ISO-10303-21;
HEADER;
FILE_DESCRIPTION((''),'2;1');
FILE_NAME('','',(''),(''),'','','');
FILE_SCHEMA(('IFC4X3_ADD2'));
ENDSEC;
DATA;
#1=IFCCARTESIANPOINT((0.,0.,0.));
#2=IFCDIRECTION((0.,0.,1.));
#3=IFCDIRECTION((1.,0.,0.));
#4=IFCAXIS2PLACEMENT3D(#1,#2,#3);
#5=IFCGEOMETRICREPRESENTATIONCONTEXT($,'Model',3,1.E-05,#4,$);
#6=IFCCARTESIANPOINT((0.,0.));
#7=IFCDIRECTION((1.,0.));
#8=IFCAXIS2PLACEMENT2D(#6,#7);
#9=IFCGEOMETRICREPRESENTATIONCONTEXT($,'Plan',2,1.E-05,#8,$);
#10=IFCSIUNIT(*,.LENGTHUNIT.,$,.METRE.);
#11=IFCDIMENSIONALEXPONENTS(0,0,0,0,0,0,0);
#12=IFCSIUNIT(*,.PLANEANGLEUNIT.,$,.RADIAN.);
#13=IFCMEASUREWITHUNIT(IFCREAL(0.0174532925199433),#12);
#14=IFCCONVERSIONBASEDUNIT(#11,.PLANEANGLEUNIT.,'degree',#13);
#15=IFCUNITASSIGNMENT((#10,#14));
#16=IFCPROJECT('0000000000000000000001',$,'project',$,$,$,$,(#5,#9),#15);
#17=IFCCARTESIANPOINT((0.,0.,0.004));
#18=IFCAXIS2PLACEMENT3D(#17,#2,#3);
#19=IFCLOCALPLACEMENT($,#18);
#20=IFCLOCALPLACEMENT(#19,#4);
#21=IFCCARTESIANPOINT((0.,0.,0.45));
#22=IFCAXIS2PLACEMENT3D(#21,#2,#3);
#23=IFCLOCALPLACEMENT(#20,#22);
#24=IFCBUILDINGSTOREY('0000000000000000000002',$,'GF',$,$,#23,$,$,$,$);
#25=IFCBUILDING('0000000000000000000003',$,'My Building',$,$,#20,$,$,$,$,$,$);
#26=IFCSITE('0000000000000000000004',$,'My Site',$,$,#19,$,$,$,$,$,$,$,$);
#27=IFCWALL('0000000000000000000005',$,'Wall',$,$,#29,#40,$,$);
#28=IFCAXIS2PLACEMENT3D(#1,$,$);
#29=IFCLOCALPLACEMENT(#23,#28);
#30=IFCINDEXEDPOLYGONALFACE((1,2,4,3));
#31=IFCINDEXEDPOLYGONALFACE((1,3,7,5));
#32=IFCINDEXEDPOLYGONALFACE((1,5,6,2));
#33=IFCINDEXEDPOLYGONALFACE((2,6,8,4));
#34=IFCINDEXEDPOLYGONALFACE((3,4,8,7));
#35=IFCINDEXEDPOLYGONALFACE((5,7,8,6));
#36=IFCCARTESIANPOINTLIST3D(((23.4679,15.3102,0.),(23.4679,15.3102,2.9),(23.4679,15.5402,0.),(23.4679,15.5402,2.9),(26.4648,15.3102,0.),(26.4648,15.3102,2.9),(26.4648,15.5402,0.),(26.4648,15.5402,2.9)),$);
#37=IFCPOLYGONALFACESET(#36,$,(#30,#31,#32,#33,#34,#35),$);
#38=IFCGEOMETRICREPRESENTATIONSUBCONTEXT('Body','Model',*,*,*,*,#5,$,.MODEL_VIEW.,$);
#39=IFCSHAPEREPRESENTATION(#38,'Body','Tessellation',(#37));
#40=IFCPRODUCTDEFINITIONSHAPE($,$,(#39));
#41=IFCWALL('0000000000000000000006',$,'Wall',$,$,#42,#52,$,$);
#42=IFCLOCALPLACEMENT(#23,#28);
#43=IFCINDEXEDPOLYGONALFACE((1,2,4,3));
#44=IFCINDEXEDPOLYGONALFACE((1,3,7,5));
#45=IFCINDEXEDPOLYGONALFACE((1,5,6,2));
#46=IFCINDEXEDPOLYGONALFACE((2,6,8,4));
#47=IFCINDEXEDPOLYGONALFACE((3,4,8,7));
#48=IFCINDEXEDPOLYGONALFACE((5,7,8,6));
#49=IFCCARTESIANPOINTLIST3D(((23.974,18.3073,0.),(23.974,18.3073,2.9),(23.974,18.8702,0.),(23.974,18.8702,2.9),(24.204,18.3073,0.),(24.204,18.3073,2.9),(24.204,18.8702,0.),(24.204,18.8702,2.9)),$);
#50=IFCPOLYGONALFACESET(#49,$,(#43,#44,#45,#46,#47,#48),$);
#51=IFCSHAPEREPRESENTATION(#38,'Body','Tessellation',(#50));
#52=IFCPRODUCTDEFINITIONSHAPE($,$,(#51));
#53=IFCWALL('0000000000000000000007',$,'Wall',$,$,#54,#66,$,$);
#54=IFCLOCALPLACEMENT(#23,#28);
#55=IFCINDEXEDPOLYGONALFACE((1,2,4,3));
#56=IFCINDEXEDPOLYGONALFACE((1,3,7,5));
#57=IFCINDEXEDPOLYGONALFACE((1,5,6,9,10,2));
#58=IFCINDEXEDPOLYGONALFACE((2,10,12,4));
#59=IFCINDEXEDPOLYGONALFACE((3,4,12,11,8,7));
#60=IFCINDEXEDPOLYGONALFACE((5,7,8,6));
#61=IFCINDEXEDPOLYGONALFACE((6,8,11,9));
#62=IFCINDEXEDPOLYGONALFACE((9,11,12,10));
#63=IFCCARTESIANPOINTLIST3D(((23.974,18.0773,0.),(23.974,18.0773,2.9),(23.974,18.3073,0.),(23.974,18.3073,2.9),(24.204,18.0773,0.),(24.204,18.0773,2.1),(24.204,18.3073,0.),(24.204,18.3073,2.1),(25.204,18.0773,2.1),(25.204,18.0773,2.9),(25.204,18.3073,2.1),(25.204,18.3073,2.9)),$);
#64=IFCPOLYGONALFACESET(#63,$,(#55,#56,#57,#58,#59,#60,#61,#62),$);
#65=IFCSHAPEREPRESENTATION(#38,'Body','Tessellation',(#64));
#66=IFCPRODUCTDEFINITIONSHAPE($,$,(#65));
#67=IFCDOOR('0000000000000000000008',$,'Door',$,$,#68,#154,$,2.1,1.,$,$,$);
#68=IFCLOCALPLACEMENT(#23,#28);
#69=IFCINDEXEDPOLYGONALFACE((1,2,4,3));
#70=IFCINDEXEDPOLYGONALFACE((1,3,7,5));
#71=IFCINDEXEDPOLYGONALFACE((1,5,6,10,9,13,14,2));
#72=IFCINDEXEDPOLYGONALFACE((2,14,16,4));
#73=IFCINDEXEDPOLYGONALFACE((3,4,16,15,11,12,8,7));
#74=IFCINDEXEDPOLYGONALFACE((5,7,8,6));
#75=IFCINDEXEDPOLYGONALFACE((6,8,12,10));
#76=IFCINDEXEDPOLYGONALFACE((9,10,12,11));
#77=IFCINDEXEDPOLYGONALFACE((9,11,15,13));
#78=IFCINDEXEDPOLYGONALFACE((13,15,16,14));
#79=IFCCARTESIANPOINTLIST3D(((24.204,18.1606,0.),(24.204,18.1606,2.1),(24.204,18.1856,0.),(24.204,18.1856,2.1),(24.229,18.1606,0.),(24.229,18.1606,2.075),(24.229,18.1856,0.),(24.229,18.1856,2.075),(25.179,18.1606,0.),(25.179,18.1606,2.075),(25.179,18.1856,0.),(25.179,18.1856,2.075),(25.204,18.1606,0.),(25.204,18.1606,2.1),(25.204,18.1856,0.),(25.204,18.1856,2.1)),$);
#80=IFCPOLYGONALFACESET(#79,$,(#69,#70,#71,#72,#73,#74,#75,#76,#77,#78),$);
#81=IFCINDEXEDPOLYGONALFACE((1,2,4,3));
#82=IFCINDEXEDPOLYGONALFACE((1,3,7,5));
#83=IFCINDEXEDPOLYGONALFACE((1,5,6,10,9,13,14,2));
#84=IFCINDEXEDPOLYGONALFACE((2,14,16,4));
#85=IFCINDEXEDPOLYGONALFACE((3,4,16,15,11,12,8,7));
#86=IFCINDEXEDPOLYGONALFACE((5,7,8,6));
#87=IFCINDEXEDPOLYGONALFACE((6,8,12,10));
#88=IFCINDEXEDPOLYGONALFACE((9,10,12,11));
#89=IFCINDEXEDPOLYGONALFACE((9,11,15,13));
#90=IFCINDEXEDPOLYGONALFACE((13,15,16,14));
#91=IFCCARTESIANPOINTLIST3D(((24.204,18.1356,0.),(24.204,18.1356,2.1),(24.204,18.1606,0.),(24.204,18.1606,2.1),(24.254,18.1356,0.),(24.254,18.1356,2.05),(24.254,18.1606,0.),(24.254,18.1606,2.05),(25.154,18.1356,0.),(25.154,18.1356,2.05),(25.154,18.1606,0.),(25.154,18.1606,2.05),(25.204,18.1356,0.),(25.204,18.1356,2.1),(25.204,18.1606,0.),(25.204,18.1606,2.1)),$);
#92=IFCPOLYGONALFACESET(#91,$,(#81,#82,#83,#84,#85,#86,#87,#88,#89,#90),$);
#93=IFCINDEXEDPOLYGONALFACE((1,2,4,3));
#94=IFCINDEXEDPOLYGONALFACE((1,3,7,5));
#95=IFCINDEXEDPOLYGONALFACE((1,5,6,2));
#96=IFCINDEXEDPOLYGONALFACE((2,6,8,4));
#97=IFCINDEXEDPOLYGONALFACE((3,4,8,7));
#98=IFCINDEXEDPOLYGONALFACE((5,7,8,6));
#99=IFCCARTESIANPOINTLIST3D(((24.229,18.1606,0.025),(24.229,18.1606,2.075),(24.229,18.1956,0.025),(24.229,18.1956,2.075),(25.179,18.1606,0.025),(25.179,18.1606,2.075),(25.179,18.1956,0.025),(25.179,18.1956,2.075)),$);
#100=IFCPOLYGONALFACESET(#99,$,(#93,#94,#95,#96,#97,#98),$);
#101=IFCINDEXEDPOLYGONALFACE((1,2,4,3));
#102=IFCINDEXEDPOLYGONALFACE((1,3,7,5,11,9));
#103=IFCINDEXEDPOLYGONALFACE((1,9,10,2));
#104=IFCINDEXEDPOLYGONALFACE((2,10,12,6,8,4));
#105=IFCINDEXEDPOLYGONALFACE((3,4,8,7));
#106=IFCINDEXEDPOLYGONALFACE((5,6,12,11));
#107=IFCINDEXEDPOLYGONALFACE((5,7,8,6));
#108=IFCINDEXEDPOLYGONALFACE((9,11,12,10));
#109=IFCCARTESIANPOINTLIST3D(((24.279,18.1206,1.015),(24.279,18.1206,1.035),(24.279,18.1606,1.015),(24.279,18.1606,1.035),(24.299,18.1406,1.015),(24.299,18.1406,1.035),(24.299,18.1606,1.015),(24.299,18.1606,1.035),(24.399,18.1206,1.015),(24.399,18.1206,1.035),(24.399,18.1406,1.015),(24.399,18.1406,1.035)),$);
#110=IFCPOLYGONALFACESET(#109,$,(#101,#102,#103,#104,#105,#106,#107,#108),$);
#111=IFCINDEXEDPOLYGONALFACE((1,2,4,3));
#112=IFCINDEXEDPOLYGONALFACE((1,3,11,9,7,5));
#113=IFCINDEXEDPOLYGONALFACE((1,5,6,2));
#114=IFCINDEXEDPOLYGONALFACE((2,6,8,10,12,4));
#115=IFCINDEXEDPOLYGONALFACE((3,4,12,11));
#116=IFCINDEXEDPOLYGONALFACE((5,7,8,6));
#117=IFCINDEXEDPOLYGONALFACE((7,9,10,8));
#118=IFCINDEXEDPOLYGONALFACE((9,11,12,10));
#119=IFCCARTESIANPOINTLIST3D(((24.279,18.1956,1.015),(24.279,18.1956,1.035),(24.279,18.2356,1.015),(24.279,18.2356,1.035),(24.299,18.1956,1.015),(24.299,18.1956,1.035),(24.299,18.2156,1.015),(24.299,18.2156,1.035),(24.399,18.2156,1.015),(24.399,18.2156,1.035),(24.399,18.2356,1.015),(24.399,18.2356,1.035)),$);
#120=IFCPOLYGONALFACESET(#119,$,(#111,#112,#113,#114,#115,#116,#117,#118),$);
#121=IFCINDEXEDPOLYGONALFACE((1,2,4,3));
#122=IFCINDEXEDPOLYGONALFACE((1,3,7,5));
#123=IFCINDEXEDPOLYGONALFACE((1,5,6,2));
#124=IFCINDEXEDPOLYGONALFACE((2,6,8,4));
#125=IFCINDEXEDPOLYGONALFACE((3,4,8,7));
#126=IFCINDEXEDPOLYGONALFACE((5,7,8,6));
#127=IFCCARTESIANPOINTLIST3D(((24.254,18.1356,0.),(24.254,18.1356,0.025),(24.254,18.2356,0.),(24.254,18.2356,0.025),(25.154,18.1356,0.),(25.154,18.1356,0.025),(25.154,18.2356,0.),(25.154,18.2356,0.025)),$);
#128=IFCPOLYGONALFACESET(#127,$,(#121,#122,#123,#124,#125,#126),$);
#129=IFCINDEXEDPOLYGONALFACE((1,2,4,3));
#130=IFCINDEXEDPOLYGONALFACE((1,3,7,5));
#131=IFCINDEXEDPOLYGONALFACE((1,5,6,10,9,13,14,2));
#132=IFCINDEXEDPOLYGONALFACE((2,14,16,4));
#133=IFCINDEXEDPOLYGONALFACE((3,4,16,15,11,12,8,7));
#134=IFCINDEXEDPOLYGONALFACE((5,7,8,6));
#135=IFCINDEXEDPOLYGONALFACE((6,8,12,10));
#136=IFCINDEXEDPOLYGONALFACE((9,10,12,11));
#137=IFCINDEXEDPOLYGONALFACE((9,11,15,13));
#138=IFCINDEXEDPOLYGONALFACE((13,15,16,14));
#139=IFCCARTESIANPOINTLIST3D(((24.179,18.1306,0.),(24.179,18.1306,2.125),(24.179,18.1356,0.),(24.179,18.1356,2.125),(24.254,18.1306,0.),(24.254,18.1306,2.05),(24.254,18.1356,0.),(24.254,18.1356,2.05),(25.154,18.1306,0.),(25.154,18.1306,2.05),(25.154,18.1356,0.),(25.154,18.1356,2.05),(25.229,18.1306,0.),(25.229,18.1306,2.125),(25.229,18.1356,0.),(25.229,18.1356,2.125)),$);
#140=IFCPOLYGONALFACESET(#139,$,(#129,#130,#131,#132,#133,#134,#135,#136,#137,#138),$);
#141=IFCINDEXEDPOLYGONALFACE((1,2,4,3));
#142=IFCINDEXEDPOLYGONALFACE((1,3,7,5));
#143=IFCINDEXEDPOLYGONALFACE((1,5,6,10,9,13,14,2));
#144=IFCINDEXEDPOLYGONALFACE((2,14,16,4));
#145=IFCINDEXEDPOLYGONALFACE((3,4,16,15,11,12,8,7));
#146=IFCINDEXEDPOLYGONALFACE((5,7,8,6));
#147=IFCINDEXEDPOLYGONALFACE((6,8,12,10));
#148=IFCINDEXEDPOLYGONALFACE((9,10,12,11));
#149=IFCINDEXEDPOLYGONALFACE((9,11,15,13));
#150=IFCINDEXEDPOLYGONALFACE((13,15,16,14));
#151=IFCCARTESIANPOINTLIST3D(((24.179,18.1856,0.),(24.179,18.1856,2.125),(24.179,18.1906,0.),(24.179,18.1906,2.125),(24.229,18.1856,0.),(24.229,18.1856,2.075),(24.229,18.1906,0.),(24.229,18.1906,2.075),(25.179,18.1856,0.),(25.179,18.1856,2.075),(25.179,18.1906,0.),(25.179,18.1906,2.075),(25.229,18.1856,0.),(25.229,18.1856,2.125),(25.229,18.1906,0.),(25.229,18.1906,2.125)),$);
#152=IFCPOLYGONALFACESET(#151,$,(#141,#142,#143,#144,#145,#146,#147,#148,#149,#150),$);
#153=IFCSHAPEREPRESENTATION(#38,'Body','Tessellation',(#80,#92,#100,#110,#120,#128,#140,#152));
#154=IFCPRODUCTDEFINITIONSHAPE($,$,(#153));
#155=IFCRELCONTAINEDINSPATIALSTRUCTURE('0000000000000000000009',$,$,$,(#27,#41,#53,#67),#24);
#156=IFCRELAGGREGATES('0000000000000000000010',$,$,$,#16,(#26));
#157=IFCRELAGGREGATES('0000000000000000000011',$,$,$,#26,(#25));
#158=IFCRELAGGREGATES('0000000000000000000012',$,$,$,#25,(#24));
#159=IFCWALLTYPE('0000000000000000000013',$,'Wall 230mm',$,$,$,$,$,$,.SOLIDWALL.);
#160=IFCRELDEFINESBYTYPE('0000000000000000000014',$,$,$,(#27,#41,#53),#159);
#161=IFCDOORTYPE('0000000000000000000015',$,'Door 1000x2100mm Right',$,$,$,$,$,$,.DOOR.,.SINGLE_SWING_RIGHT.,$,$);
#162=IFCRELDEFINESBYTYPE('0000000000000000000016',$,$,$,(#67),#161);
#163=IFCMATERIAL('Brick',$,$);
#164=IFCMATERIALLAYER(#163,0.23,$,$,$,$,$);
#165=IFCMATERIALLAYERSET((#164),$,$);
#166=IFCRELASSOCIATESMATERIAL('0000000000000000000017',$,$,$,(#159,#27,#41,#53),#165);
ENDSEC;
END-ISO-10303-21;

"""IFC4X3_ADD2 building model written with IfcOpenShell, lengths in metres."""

from ifc_helpers import new_model, entity, si_unit, converted_unit, frame, origin_with_axes, origin_2d_with_axis, place, context, subcontext, project, spatial, line, indexed_curve, outline, extrude, shape, source, transform, mapped, material, layer, layer_set, layer_usage, type_object, type_shapes, element, fill, save


model = new_model("IFC4X3_ADD2")

# Units and contexts
model_context = context("Model", 3, precision=1e-05, world=origin_with_axes())
plan_context = context("Plan", 2, precision=1e-05, world=origin_2d_with_axis())
body_context_1 = subcontext(model_context, "Body", "Model", "MODEL_VIEW")
body_context_2 = subcontext(plan_context, "Body", "Plan", "PLAN_VIEW")
ifc_project = project(units=[si_unit("LENGTHUNIT", "METRE"), converted_unit("PLANEANGLEUNIT", "degree", entity("IfcReal", 0.0174532925199433), si_unit("PLANEANGLEUNIT", "RADIAN"), dimensions=[0, 0, 0, 0, 0, 0, 0])], contexts=[model_context, plan_context])

# Site, building, storey
site_placement = place(None, frame((0.0, 0.0, 0.004), z_axis=(0.0, 0.0, 1.0), x_axis=(1.0, 0.0, 0.0)))
site = spatial("IfcSite", under=ifc_project, at=site_placement, Name="My Site")
building_placement = place(site_placement, origin_with_axes())
building = spatial("IfcBuilding", under=site, at=building_placement, Name="My Building")
storey_placement = place(building_placement, frame((0.0, 0.0, 0.45), z_axis=(0.0, 0.0, 1.0), x_axis=(1.0, 0.0, 0.0)))
storey = spatial("IfcBuildingStorey", under=building, at=storey_placement, Name="GF")

# Shared definitions
ifc_material = material(Name="Brick")

# Shared definitions
ifc_layer_1 = layer(ifc_material, 0.23)
ifc_layer_set_1 = layer_set([ifc_layer_1])
wall_type_1 = type_object("IfcWallType", Name="Wall 230mm", PredefinedType="SOLIDWALL", material=ifc_layer_set_1)

# Shared definitions
shared_shape_1 = source(origin_with_axes(), body_context_1, "Body", "SweptSolid", [
    extrude(outline(indexed_curve([(0.0, 0.0), (1.0, 0.0), (1.0, 2.1), (0.0, 2.1)], segments=[line(1, 2, 3, 4, 1)])), frame((0.0, -0.6, 0.0), z_axis=(0.0, -1.0, 0.0), x_axis=(1.0, 0.0, 0.0)), (0.0, 0.0, -1.0), 1.2),
])
door_type = type_object("IfcDoorType", Name="Door 1000x2100mm Right", OperationType="SINGLE_SWING_RIGHT", PredefinedType="DOOR")
shared_shape_2 = source(origin_with_axes(), body_context_1, "Body", "SweptSolid", [
    extrude(outline(indexed_curve([(0.0, 0.0), (0.0, 2.1), (1.0, 2.1), (1.0, 0.0), (0.975, 0.0), (0.975, 2.075), (0.025, 2.075), (0.025, 0.0)], segments=[line(1, 2, 3, 4, 5, 6, 7, 8, 1)])), frame((0.0, 0.025, 0.0), z_axis=(0.0, -1.0, 0.0), x_axis=(1.0, 0.0, 0.0)), (0.0, 0.0, -1.0), 0.025),
    extrude(outline(indexed_curve([(0.0, 0.0), (0.0, 2.1), (1.0, 2.1), (1.0, 0.0), (0.95, 0.0), (0.95, 2.05), (0.05, 2.05), (0.05, 0.0)], segments=[line(1, 2, 3, 4, 5, 6, 7, 8, 1)])), frame((0.0, 0.0, 0.0), z_axis=(0.0, -1.0, 0.0), x_axis=(1.0, 0.0, 0.0)), (0.0, 0.0, -1.0), 0.025),
    extrude(outline(indexed_curve([(0.0, 0.0), (0.95, 0.0), (0.95, 0.035), (0.0, 0.035)], segments=[line(1, 2, 3, 4, 1)])), frame((0.025, 0.025, 0.025), z_axis=(0.0, 0.0, 1.0), x_axis=(1.0, 0.0, 0.0)), (0.0, 0.0, 1.0), 2.05),
    extrude(outline(indexed_curve([(0.0, 0.0), (0.0, -0.04), (0.12, -0.04), (0.12, -0.02), (0.02, -0.02), (0.02, 0.0)], segments=[line(1, 2, 3, 4, 5, 6, 1)])), frame((0.075, 0.025, 1.015), z_axis=(0.0, 0.0, 1.0), x_axis=(1.0, 0.0, 0.0)), (0.0, 0.0, 1.0), 0.02),
    extrude(outline(indexed_curve([(0.0, 0.0), (0.0, 0.04), (0.12, 0.04), (0.12, 0.02), (0.02, 0.02), (0.02, 0.0)], segments=[line(1, 2, 3, 4, 5, 6, 1)])), frame((0.075, 0.06, 1.015), z_axis=(0.0, 0.0, 1.0), x_axis=(1.0, 0.0, 0.0)), (0.0, 0.0, 1.0), 0.02),
    extrude(outline(indexed_curve([(0.0, 0.0), (0.9, 0.0), (0.9, 0.1), (0.0, 0.1)], segments=[line(1, 2, 3, 4, 1)])), frame((0.05, 0.0, 0.0), z_axis=(0.0, 0.0, 1.0), x_axis=(1.0, 0.0, 0.0)), (0.0, 0.0, 1.0), 0.025),
    extrude(outline(indexed_curve([(0.0, 0.0), (0.0, 2.125), (1.05, 2.125), (1.05, 0.0), (0.975, 0.0), (0.975, 2.05), (0.075, 2.05), (0.075, 0.0)], segments=[line(1, 2, 3, 4, 5, 6, 7, 8, 1)])), frame((-0.025, -0.005, 0.0), z_axis=(0.0, -1.0, 0.0), x_axis=(1.0, 0.0, 0.0)), (0.0, 0.0, -1.0), 0.005),
    extrude(outline(indexed_curve([(0.0, 0.0), (0.0, 2.125), (1.05, 2.125), (1.05, 0.0), (1.0, 0.0), (1.0, 2.075), (0.05, 2.075), (0.05, 0.0)], segments=[line(1, 2, 3, 4, 5, 6, 7, 8, 1)])), frame((-0.025, 0.05, 0.0), z_axis=(0.0, -1.0, 0.0), x_axis=(1.0, 0.0, 0.0)), (0.0, 0.0, -1.0), 0.005),
])
shared_shape_3 = source(origin_with_axes(), body_context_2, "Body", "Curve2D", [
    entity("IfcIndexedPolyCurve", entity("IfcCartesianPointList2D", [[0.0, 0.0], [0.0, 0.05], [0.025, 0.05], [0.025, 0.025], [0.05, 0.025], [0.05, 0.0]]), [entity("IfcLineIndex", [1, 2, 3, 4, 5, 6, 1])]),
    entity("IfcIndexedPolyCurve", entity("IfcCartesianPointList2D", [[1.0, 0.0], [1.0, 0.05], [0.975, 0.05], [0.975, 0.025], [0.95, 0.025], [0.95, 0.0]]), [entity("IfcLineIndex", [1, 2, 3, 4, 5, 6, 1])]),
    entity("IfcTrimmedCurve", entity("IfcEllipse", entity("IfcAxis2Placement2D", entity("IfcCartesianPoint", [0.94, 0.05]), entity("IfcDirection", [1.0, 0.0])), 0.915, 0.95), [entity("IfcCartesianPoint", [0.94, 1.0])], [entity("IfcCartesianPoint", [0.025, 0.05])], True, "CARTESIAN"),
    entity("IfcIndexedPolyCurve", entity("IfcCartesianPointList2D", [[0.975, 0.05], [0.94, 0.05], [0.94, 1.0], [0.975, 1.0]]), [entity("IfcLineIndex", [1, 2, 3, 4, 1])]),
])
type_shapes(door_type, [shared_shape_2, shared_shape_3])

# Walls
ifc_layer_usage_1 = layer_usage(ifc_layer_set_1, "AXIS2", "POSITIVE", 0.0)
wall_1_placement = place(storey_placement, frame((26.4648, 15.5402, 0.0), z_axis=(0.0, 0.0, 1.0), x_axis=(-1.0, 0.0, 0.0)))
element("IfcWall", 1, at=wall_1_placement, inside=storey, type_object=wall_type_1, material=ifc_layer_usage_1, Name="Wall", context=body_context_1, shape_type="SweptSolid", body=[
    extrude(outline(indexed_curve([(0.0, 0.0), (0.0, 0.23), (2.9969, 0.23), (2.9969, 0.0), (0.0, 0.0)], self_intersect=False)), origin_with_axes(), (0.0, 0.0, 1.0), 2.9),
])
ifc_layer_usage_2 = layer_usage(ifc_layer_set_1, "AXIS2", "POSITIVE", 0.0)
wall_2_placement = place(storey_placement, frame((24.204, 18.3073, 0.0), z_axis=(0.0, 0.0, 1.0), x_axis=(0.000001, 1.0, 0.0)))
element("IfcWall", 2, at=wall_2_placement, inside=storey, type_object=wall_type_1, material=ifc_layer_usage_2, Name="Wall", context=body_context_1, shape_type="SweptSolid", body=[
    extrude(outline(indexed_curve([(0.0, 0.0), (0.0, 0.23), (0.5629, 0.23), (0.5629, 0.0), (0.0, 0.0)], self_intersect=False)), origin_with_axes(), (0.0, 0.0, 1.0), 2.9),
])

# Wall, opening, door
ifc_layer_usage_3 = layer_usage(ifc_layer_set_1, "AXIS2", "POSITIVE", 0.0)
wall_3_placement = place(storey_placement, frame((25.204, 18.3073, 0.0), z_axis=(0.0, 0.0, 1.0), x_axis=(-1.0, 0.0, 0.0)))
wall_3 = element("IfcWall", 3, at=wall_3_placement, inside=storey, type_object=wall_type_1, material=ifc_layer_usage_3, Name="Wall", context=body_context_1, shape_type="SweptSolid", body=[
    extrude(outline(indexed_curve([(0.0, 0.0), (0.0, 0.23), (1.23, 0.23), (1.23, 0.0), (0.0, 0.0)], self_intersect=False)), origin_with_axes(), (0.0, 0.0, 1.0), 2.9),
])
opening_1_placement = place(wall_3_placement, frame((0.0, 0.0, 0.0), z_axis=(0.0, 0.0, 1.0), x_axis=(1.0, 0.0, 0.0)))
opening_1 = element("IfcOpeningElement", 4, at=opening_1_placement, cuts=wall_3, PredefinedType="OPENING", context=body_context_1, shape_type="MappedRepresentation", body=[
    mapped(shared_shape_1, transform((0.0, 0.0, 0.0), x_axis=(1.0, 0.0, 0.0), y_axis=(0.0, 1.0, 0.0), z_axis=(0.0, 0.0, 1.0), scale=1.0)),
])
door_1_placement = place(opening_1_placement, frame((1.0, 0.1717, 0.0), z_axis=(0.0, 0.0, 1.0), x_axis=(-1.0, 0.0, 0.0)))
door_1 = element("IfcDoor", 5, at=door_1_placement, inside=storey, type_object=door_type, Name="Door", OverallHeight=2.1, OverallWidth=1.0, shapes=[
    shape(body_context_1, "Body", "MappedRepresentation", [mapped(shared_shape_2, transform((0.0, 0.0, 0.0), x_axis=(1.0, 0.0, 0.0), y_axis=(0.0, 1.0, 0.0), z_axis=(0.0, 0.0, 1.0), scale=1.0))]),
    shape(body_context_2, "Body", "MappedRepresentation", [mapped(shared_shape_3, transform((0.0, 0.0, 0.0), x_axis=(1.0, 0.0, 0.0), y_axis=(0.0, 1.0, 0.0), z_axis=(0.0, 0.0, 1.0), scale=1.0))]),
])
fill(opening_1, door_1)

save(model, "model.ifc")
